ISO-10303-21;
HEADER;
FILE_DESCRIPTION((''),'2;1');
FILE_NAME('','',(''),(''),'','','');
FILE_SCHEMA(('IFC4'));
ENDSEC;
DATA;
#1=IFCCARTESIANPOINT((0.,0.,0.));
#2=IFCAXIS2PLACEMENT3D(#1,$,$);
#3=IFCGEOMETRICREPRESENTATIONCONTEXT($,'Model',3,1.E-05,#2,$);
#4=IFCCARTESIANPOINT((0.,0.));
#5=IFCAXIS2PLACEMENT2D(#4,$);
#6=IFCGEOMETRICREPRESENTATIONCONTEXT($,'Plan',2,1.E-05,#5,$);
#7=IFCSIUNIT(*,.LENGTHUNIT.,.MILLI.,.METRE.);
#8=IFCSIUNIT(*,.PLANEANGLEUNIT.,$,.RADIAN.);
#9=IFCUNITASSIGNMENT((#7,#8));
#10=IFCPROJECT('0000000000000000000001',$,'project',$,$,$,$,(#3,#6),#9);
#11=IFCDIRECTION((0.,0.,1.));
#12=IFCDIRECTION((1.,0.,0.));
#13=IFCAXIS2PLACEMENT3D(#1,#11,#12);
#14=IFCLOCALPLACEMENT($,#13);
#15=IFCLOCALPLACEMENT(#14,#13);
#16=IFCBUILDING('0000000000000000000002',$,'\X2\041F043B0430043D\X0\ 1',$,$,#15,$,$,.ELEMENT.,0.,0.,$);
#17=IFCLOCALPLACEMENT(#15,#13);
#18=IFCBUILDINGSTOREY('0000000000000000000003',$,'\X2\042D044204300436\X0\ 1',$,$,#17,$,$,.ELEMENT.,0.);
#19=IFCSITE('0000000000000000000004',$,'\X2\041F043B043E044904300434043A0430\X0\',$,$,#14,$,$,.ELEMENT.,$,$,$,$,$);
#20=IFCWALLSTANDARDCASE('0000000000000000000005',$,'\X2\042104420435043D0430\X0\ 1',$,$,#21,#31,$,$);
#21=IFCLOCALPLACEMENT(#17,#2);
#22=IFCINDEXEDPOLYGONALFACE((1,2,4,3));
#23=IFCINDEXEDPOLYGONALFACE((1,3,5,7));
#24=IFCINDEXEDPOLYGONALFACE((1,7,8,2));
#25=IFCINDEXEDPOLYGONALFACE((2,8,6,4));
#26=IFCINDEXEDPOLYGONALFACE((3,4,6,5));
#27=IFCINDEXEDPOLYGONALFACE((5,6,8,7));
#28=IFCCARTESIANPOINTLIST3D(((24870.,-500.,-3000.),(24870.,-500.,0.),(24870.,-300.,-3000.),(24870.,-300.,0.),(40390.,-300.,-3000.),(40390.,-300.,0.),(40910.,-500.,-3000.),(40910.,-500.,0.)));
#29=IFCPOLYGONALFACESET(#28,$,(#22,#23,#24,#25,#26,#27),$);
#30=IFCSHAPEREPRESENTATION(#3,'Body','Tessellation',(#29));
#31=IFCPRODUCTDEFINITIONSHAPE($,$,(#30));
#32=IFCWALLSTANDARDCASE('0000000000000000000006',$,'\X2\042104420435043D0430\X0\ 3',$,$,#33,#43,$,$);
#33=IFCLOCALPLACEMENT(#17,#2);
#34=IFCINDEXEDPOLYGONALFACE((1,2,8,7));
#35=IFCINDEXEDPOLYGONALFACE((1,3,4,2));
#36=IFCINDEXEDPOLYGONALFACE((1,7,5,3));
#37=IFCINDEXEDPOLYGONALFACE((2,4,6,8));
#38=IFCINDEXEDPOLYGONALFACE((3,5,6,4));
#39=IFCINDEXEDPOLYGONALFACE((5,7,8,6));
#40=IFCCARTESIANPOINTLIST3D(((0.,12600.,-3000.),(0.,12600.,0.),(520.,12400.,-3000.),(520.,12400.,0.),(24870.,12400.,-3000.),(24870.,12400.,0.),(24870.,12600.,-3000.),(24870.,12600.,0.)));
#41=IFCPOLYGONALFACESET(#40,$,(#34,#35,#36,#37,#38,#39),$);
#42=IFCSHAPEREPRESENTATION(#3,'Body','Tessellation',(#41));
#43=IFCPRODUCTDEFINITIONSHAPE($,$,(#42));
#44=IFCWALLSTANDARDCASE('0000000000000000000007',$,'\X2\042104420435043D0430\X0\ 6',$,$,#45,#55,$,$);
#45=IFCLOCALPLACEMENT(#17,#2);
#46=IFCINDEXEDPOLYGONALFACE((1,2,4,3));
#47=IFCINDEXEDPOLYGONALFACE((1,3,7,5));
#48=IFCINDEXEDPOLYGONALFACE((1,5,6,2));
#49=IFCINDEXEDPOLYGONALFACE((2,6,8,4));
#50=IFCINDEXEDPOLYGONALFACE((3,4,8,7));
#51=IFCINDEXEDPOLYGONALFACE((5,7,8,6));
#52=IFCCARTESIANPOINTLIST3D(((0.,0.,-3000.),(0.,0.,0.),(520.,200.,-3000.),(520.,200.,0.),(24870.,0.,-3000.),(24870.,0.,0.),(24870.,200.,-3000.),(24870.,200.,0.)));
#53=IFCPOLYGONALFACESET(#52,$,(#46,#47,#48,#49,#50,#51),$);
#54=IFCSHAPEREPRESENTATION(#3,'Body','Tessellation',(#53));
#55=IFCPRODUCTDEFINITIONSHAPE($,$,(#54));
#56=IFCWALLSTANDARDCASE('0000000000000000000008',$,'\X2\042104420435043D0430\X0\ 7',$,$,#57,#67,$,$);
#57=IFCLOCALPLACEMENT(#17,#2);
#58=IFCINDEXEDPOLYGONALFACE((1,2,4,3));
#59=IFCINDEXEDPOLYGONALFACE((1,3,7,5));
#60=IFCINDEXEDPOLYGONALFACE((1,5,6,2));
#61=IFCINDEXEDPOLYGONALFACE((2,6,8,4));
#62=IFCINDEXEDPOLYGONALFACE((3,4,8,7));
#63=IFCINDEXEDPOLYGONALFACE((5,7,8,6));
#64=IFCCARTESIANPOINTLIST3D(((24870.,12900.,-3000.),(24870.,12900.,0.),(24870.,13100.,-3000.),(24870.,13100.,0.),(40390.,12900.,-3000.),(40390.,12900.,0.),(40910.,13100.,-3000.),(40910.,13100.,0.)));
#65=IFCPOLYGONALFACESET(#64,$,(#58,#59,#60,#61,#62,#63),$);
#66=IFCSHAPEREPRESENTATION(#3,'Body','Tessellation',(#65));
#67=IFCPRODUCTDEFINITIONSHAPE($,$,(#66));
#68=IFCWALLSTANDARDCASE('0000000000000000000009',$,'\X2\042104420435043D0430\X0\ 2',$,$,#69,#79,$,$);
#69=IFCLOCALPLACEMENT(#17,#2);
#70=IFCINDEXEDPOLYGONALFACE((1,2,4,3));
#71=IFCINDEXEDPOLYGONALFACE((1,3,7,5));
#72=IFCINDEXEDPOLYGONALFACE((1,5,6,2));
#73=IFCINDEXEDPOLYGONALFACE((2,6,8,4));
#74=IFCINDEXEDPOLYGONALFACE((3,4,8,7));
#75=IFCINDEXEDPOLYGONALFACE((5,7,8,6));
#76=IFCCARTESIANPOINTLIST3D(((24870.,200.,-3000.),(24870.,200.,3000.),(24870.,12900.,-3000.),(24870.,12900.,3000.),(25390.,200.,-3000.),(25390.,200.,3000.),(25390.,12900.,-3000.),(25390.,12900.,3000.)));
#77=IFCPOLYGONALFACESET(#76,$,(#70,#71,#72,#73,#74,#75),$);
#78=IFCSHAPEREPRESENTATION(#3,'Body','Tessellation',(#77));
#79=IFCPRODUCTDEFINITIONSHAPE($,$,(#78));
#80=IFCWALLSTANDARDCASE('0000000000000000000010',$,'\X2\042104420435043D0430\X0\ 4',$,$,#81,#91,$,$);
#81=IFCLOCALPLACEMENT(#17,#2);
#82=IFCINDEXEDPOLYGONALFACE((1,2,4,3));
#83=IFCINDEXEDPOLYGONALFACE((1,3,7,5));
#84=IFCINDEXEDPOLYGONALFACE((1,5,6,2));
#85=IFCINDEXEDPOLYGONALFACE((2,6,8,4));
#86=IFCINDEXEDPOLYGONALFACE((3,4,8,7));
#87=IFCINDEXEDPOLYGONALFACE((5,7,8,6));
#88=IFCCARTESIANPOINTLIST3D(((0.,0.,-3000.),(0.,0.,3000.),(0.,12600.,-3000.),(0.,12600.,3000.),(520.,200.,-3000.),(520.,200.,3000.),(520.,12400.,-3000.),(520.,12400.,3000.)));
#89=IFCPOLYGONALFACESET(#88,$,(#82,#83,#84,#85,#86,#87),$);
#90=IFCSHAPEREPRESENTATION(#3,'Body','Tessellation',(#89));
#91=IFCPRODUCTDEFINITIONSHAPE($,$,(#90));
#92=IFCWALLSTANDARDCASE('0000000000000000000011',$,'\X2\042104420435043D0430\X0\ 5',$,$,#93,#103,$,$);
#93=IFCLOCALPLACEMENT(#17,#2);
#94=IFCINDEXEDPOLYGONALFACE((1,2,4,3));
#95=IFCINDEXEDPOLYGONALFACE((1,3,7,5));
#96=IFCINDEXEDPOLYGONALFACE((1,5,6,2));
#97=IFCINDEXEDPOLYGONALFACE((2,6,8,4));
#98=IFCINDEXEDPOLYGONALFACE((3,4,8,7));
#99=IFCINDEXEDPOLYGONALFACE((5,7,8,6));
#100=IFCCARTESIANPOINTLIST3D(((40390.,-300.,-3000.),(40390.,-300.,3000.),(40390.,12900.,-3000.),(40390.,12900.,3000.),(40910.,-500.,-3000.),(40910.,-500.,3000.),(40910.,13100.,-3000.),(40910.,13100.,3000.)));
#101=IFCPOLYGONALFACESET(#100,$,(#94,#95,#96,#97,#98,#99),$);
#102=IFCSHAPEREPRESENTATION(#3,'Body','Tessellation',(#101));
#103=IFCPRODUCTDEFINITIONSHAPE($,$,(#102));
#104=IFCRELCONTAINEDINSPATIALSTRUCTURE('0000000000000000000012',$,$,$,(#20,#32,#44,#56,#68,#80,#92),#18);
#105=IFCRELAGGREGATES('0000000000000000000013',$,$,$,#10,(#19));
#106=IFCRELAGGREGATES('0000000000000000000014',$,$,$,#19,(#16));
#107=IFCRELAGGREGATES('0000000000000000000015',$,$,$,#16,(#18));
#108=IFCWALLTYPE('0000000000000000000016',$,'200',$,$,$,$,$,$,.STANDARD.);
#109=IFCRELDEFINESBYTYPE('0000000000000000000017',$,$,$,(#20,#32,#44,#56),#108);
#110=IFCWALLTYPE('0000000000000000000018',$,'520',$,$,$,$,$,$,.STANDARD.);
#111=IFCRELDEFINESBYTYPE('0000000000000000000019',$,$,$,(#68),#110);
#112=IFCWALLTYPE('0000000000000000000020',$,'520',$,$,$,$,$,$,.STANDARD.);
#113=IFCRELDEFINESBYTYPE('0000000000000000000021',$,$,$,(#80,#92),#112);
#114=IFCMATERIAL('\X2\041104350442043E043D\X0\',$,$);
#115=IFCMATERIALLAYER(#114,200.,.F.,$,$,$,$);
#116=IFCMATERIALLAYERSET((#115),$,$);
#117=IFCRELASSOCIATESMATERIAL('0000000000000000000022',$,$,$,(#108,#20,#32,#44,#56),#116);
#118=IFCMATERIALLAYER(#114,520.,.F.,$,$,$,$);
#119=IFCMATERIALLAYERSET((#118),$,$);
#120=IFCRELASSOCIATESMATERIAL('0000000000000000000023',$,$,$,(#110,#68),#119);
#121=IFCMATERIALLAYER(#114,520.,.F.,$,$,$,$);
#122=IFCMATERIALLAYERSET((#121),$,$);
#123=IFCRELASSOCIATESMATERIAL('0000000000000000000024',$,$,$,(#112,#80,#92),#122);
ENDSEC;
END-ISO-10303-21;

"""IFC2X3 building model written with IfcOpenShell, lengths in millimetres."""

from ifc_helpers import new_model, si_unit, frame, origin, origin_with_axes, origin_2d, place, context, project, spatial, polyline, segment, composite_curve, outline, extrude, material, layer, layer_set, layer_usage, type_object, element, save


model = new_model("IFC2X3")

# Units and contexts
model_context = context("Model", 3, precision=1e-05, world=origin())
plan_context = context("Plan", 2, precision=1e-05, world=origin_2d())
ifc_project = project(units=[si_unit("LENGTHUNIT", "METRE", prefix="MILLI"), si_unit("PLANEANGLEUNIT", "RADIAN")], contexts=[model_context, plan_context])

# Site, building, storey
site_placement = place(None, origin_with_axes())
site = spatial("IfcSite", under=ifc_project, at=site_placement, Name="Площадка", CompositionType="ELEMENT")
building_placement = place(site_placement, origin_with_axes())
building = spatial("IfcBuilding", under=site, at=building_placement, Name="План 1", CompositionType="ELEMENT", ElevationOfRefHeight=0.0, ElevationOfTerrain=0.0)
storey_placement = place(building_placement, origin_with_axes())
storey = spatial("IfcBuildingStorey", under=building, at=storey_placement, Name="Этаж 1", CompositionType="ELEMENT", Elevation=0.0)

# Walls
ifc_material = material(Name="Бетон")
ifc_layer_1 = layer(ifc_material, 200.0, ventilated=False)
ifc_layer_set_1 = layer_set([ifc_layer_1])
ifc_layer_usage_1 = layer_usage(ifc_layer_set_1, "AXIS2", "POSITIVE", 0.0)
wall_type_1 = type_object("IfcWallType", Name="200", PredefinedType="STANDARD", material=ifc_layer_set_1)
wall_1_placement = place(storey_placement, frame((24870.0, -500.0, -3000.0), z_axis=(0.0, 0.0, 1.0), x_axis=(1.0, 0.0, 0.0)))
element("IfcWallStandardCase", 1, at=wall_1_placement, inside=storey, type_object=wall_type_1, material=ifc_layer_usage_1, Name="Стена 1", context=model_context, shape_type="SweptSolid", body=[
    extrude(outline(composite_curve([segment(polyline([(0.0, 200.0), (0.0, 0.0)]), True, "CONTINUOUS"), segment(polyline([(0.0, 0.0), (16040.0, 0.0)]), True, "CONTINUOUS"), segment(polyline([(16040.0, 0.0), (15520.0, 200.0)]), True, "CONTINUOUS"), segment(polyline([(15520.0, 200.0), (0.0, 200.0)]), True, "CONTINUOUS")], self_intersect=False)), origin_with_axes(), (0.0, 0.0, 1.0), 3000.0),
])
ifc_layer_usage_2 = layer_usage(ifc_layer_set_1, "AXIS2", "POSITIVE", 0.0)
wall_2_placement = place(storey_placement, frame((24870.0, 12600.0, -3000.0), z_axis=(0.0, 0.0, 1.0), x_axis=(-1.0, 0.0, 0.0)))
element("IfcWallStandardCase", 2, at=wall_2_placement, inside=storey, type_object=wall_type_1, material=ifc_layer_usage_2, Name="Стена 3", context=model_context, shape_type="SweptSolid", body=[
    extrude(outline(composite_curve([segment(polyline([(0.0, 200.0), (0.0, 0.0)]), True, "CONTINUOUS"), segment(polyline([(0.0, 0.0), (24870.0, 0.0)]), True, "CONTINUOUS"), segment(polyline([(24870.0, 0.0), (24350.0, 200.0)]), True, "CONTINUOUS"), segment(polyline([(24350.0, 200.0), (0.0, 200.0)]), True, "CONTINUOUS")], self_intersect=False)), origin_with_axes(), (0.0, 0.0, 1.0), 3000.0),
])
ifc_layer_usage_3 = layer_usage(ifc_layer_set_1, "AXIS2", "POSITIVE", 0.0)
wall_3_placement = place(storey_placement, frame((0.0, 0.0, -3000.0), z_axis=(0.0, 0.0, 1.0), x_axis=(1.0, 0.0, 0.0)))
element("IfcWallStandardCase", 3, at=wall_3_placement, inside=storey, type_object=wall_type_1, material=ifc_layer_usage_3, Name="Стена 6", context=model_context, shape_type="SweptSolid", body=[
    extrude(outline(composite_curve([segment(polyline([(520.0, 200.0), (0.0, 0.0)]), True, "CONTINUOUS"), segment(polyline([(0.0, 0.0), (24870.0, 0.0)]), True, "CONTINUOUS"), segment(polyline([(24870.0, 0.0), (24870.0, 200.0)]), True, "CONTINUOUS"), segment(polyline([(24870.0, 200.0), (520.0, 200.0)]), True, "CONTINUOUS")], self_intersect=False)), origin_with_axes(), (0.0, 0.0, 1.0), 3000.0),
])
ifc_layer_usage_4 = layer_usage(ifc_layer_set_1, "AXIS2", "POSITIVE", 0.0)
wall_4_placement = place(storey_placement, frame((40910.0, 13100.0, -3000.0), z_axis=(0.0, 0.0, 1.0), x_axis=(-1.0, 0.0, 0.0)))
element("IfcWallStandardCase", 4, at=wall_4_placement, inside=storey, type_object=wall_type_1, material=ifc_layer_usage_4, Name="Стена 7", context=model_context, shape_type="SweptSolid", body=[
    extrude(outline(composite_curve([segment(polyline([(520.0, 200.0), (0.0, 0.0)]), True, "CONTINUOUS"), segment(polyline([(0.0, 0.0), (16040.0, 0.0)]), True, "CONTINUOUS"), segment(polyline([(16040.0, 0.0), (16040.0, 200.0)]), True, "CONTINUOUS"), segment(polyline([(16040.0, 200.0), (520.0, 200.0)]), True, "CONTINUOUS")], self_intersect=False)), origin_with_axes(), (0.0, 0.0, 1.0), 3000.0),
])
ifc_layer_2 = layer(ifc_material, 520.0, ventilated=False)
ifc_layer_set_2 = layer_set([ifc_layer_2])
ifc_layer_usage_5 = layer_usage(ifc_layer_set_2, "AXIS2", "POSITIVE", 0.0)
wall_type_2 = type_object("IfcWallType", Name="520", PredefinedType="STANDARD", material=ifc_layer_set_2)
wall_5_placement = place(storey_placement, frame((25390.0, 200.0, -3000.0), z_axis=(0.0, 0.0, 1.0), x_axis=(0.0, 1.0, 0.0)))
element("IfcWallStandardCase", 5, at=wall_5_placement, inside=storey, type_object=wall_type_2, material=ifc_layer_usage_5, Name="Стена 2", context=model_context, shape_type="SweptSolid", body=[
    extrude(outline(composite_curve([segment(polyline([(0.0, 520.0), (0.0, 0.0)]), True, "CONTINUOUS"), segment(polyline([(0.0, 0.0), (12700.0, 0.0)]), True, "CONTINUOUS"), segment(polyline([(12700.0, 0.0), (12700.0, 520.0)]), True, "CONTINUOUS"), segment(polyline([(12700.0, 520.0), (0.0, 520.0)]), True, "CONTINUOUS")], self_intersect=False)), origin_with_axes(), (0.0, 0.0, 1.0), 6000.0),
])
ifc_layer_3 = layer(ifc_material, 520.0, ventilated=False)
ifc_layer_set_3 = layer_set([ifc_layer_3])
ifc_layer_usage_6 = layer_usage(ifc_layer_set_3, "AXIS2", "POSITIVE", 0.0)
wall_type_3 = type_object("IfcWallType", Name="520", PredefinedType="STANDARD", material=ifc_layer_set_3)
wall_6_placement = place(storey_placement, frame((0.0, 12600.0, -3000.0), z_axis=(0.0, 0.0, 1.0), x_axis=(0.0, -1.0, 0.0)))
element("IfcWallStandardCase", 6, at=wall_6_placement, inside=storey, type_object=wall_type_3, material=ifc_layer_usage_6, Name="Стена 4", context=model_context, shape_type="SweptSolid", body=[
    extrude(outline(composite_curve([segment(polyline([(200.0, 520.0), (0.0, 0.0)]), True, "CONTINUOUS"), segment(polyline([(0.0, 0.0), (12600.0, 0.0)]), True, "CONTINUOUS"), segment(polyline([(12600.0, 0.0), (12400.0, 520.0)]), True, "CONTINUOUS"), segment(polyline([(12400.0, 520.0), (200.0, 520.0)]), True, "CONTINUOUS")], self_intersect=False)), origin_with_axes(), (0.0, 0.0, 1.0), 6000.0),
])
ifc_layer_usage_7 = layer_usage(ifc_layer_set_3, "AXIS2", "POSITIVE", 0.0)
wall_7_placement = place(storey_placement, frame((40910.0, -500.0, -3000.0), z_axis=(0.0, 0.0, 1.0), x_axis=(0.0, 1.0, 0.0)))
element("IfcWallStandardCase", 7, at=wall_7_placement, inside=storey, type_object=wall_type_3, material=ifc_layer_usage_7, Name="Стена 5", context=model_context, shape_type="SweptSolid", body=[
    extrude(outline(composite_curve([segment(polyline([(200.0, 520.0), (0.0, 0.0)]), True, "CONTINUOUS"), segment(polyline([(0.0, 0.0), (13600.0, 0.0)]), True, "CONTINUOUS"), segment(polyline([(13600.0, 0.0), (13400.0, 520.0)]), True, "CONTINUOUS"), segment(polyline([(13400.0, 520.0), (200.0, 520.0)]), True, "CONTINUOUS")], self_intersect=False)), origin_with_axes(), (0.0, 0.0, 1.0), 6000.0),
])

save(model, "model.ifc")
